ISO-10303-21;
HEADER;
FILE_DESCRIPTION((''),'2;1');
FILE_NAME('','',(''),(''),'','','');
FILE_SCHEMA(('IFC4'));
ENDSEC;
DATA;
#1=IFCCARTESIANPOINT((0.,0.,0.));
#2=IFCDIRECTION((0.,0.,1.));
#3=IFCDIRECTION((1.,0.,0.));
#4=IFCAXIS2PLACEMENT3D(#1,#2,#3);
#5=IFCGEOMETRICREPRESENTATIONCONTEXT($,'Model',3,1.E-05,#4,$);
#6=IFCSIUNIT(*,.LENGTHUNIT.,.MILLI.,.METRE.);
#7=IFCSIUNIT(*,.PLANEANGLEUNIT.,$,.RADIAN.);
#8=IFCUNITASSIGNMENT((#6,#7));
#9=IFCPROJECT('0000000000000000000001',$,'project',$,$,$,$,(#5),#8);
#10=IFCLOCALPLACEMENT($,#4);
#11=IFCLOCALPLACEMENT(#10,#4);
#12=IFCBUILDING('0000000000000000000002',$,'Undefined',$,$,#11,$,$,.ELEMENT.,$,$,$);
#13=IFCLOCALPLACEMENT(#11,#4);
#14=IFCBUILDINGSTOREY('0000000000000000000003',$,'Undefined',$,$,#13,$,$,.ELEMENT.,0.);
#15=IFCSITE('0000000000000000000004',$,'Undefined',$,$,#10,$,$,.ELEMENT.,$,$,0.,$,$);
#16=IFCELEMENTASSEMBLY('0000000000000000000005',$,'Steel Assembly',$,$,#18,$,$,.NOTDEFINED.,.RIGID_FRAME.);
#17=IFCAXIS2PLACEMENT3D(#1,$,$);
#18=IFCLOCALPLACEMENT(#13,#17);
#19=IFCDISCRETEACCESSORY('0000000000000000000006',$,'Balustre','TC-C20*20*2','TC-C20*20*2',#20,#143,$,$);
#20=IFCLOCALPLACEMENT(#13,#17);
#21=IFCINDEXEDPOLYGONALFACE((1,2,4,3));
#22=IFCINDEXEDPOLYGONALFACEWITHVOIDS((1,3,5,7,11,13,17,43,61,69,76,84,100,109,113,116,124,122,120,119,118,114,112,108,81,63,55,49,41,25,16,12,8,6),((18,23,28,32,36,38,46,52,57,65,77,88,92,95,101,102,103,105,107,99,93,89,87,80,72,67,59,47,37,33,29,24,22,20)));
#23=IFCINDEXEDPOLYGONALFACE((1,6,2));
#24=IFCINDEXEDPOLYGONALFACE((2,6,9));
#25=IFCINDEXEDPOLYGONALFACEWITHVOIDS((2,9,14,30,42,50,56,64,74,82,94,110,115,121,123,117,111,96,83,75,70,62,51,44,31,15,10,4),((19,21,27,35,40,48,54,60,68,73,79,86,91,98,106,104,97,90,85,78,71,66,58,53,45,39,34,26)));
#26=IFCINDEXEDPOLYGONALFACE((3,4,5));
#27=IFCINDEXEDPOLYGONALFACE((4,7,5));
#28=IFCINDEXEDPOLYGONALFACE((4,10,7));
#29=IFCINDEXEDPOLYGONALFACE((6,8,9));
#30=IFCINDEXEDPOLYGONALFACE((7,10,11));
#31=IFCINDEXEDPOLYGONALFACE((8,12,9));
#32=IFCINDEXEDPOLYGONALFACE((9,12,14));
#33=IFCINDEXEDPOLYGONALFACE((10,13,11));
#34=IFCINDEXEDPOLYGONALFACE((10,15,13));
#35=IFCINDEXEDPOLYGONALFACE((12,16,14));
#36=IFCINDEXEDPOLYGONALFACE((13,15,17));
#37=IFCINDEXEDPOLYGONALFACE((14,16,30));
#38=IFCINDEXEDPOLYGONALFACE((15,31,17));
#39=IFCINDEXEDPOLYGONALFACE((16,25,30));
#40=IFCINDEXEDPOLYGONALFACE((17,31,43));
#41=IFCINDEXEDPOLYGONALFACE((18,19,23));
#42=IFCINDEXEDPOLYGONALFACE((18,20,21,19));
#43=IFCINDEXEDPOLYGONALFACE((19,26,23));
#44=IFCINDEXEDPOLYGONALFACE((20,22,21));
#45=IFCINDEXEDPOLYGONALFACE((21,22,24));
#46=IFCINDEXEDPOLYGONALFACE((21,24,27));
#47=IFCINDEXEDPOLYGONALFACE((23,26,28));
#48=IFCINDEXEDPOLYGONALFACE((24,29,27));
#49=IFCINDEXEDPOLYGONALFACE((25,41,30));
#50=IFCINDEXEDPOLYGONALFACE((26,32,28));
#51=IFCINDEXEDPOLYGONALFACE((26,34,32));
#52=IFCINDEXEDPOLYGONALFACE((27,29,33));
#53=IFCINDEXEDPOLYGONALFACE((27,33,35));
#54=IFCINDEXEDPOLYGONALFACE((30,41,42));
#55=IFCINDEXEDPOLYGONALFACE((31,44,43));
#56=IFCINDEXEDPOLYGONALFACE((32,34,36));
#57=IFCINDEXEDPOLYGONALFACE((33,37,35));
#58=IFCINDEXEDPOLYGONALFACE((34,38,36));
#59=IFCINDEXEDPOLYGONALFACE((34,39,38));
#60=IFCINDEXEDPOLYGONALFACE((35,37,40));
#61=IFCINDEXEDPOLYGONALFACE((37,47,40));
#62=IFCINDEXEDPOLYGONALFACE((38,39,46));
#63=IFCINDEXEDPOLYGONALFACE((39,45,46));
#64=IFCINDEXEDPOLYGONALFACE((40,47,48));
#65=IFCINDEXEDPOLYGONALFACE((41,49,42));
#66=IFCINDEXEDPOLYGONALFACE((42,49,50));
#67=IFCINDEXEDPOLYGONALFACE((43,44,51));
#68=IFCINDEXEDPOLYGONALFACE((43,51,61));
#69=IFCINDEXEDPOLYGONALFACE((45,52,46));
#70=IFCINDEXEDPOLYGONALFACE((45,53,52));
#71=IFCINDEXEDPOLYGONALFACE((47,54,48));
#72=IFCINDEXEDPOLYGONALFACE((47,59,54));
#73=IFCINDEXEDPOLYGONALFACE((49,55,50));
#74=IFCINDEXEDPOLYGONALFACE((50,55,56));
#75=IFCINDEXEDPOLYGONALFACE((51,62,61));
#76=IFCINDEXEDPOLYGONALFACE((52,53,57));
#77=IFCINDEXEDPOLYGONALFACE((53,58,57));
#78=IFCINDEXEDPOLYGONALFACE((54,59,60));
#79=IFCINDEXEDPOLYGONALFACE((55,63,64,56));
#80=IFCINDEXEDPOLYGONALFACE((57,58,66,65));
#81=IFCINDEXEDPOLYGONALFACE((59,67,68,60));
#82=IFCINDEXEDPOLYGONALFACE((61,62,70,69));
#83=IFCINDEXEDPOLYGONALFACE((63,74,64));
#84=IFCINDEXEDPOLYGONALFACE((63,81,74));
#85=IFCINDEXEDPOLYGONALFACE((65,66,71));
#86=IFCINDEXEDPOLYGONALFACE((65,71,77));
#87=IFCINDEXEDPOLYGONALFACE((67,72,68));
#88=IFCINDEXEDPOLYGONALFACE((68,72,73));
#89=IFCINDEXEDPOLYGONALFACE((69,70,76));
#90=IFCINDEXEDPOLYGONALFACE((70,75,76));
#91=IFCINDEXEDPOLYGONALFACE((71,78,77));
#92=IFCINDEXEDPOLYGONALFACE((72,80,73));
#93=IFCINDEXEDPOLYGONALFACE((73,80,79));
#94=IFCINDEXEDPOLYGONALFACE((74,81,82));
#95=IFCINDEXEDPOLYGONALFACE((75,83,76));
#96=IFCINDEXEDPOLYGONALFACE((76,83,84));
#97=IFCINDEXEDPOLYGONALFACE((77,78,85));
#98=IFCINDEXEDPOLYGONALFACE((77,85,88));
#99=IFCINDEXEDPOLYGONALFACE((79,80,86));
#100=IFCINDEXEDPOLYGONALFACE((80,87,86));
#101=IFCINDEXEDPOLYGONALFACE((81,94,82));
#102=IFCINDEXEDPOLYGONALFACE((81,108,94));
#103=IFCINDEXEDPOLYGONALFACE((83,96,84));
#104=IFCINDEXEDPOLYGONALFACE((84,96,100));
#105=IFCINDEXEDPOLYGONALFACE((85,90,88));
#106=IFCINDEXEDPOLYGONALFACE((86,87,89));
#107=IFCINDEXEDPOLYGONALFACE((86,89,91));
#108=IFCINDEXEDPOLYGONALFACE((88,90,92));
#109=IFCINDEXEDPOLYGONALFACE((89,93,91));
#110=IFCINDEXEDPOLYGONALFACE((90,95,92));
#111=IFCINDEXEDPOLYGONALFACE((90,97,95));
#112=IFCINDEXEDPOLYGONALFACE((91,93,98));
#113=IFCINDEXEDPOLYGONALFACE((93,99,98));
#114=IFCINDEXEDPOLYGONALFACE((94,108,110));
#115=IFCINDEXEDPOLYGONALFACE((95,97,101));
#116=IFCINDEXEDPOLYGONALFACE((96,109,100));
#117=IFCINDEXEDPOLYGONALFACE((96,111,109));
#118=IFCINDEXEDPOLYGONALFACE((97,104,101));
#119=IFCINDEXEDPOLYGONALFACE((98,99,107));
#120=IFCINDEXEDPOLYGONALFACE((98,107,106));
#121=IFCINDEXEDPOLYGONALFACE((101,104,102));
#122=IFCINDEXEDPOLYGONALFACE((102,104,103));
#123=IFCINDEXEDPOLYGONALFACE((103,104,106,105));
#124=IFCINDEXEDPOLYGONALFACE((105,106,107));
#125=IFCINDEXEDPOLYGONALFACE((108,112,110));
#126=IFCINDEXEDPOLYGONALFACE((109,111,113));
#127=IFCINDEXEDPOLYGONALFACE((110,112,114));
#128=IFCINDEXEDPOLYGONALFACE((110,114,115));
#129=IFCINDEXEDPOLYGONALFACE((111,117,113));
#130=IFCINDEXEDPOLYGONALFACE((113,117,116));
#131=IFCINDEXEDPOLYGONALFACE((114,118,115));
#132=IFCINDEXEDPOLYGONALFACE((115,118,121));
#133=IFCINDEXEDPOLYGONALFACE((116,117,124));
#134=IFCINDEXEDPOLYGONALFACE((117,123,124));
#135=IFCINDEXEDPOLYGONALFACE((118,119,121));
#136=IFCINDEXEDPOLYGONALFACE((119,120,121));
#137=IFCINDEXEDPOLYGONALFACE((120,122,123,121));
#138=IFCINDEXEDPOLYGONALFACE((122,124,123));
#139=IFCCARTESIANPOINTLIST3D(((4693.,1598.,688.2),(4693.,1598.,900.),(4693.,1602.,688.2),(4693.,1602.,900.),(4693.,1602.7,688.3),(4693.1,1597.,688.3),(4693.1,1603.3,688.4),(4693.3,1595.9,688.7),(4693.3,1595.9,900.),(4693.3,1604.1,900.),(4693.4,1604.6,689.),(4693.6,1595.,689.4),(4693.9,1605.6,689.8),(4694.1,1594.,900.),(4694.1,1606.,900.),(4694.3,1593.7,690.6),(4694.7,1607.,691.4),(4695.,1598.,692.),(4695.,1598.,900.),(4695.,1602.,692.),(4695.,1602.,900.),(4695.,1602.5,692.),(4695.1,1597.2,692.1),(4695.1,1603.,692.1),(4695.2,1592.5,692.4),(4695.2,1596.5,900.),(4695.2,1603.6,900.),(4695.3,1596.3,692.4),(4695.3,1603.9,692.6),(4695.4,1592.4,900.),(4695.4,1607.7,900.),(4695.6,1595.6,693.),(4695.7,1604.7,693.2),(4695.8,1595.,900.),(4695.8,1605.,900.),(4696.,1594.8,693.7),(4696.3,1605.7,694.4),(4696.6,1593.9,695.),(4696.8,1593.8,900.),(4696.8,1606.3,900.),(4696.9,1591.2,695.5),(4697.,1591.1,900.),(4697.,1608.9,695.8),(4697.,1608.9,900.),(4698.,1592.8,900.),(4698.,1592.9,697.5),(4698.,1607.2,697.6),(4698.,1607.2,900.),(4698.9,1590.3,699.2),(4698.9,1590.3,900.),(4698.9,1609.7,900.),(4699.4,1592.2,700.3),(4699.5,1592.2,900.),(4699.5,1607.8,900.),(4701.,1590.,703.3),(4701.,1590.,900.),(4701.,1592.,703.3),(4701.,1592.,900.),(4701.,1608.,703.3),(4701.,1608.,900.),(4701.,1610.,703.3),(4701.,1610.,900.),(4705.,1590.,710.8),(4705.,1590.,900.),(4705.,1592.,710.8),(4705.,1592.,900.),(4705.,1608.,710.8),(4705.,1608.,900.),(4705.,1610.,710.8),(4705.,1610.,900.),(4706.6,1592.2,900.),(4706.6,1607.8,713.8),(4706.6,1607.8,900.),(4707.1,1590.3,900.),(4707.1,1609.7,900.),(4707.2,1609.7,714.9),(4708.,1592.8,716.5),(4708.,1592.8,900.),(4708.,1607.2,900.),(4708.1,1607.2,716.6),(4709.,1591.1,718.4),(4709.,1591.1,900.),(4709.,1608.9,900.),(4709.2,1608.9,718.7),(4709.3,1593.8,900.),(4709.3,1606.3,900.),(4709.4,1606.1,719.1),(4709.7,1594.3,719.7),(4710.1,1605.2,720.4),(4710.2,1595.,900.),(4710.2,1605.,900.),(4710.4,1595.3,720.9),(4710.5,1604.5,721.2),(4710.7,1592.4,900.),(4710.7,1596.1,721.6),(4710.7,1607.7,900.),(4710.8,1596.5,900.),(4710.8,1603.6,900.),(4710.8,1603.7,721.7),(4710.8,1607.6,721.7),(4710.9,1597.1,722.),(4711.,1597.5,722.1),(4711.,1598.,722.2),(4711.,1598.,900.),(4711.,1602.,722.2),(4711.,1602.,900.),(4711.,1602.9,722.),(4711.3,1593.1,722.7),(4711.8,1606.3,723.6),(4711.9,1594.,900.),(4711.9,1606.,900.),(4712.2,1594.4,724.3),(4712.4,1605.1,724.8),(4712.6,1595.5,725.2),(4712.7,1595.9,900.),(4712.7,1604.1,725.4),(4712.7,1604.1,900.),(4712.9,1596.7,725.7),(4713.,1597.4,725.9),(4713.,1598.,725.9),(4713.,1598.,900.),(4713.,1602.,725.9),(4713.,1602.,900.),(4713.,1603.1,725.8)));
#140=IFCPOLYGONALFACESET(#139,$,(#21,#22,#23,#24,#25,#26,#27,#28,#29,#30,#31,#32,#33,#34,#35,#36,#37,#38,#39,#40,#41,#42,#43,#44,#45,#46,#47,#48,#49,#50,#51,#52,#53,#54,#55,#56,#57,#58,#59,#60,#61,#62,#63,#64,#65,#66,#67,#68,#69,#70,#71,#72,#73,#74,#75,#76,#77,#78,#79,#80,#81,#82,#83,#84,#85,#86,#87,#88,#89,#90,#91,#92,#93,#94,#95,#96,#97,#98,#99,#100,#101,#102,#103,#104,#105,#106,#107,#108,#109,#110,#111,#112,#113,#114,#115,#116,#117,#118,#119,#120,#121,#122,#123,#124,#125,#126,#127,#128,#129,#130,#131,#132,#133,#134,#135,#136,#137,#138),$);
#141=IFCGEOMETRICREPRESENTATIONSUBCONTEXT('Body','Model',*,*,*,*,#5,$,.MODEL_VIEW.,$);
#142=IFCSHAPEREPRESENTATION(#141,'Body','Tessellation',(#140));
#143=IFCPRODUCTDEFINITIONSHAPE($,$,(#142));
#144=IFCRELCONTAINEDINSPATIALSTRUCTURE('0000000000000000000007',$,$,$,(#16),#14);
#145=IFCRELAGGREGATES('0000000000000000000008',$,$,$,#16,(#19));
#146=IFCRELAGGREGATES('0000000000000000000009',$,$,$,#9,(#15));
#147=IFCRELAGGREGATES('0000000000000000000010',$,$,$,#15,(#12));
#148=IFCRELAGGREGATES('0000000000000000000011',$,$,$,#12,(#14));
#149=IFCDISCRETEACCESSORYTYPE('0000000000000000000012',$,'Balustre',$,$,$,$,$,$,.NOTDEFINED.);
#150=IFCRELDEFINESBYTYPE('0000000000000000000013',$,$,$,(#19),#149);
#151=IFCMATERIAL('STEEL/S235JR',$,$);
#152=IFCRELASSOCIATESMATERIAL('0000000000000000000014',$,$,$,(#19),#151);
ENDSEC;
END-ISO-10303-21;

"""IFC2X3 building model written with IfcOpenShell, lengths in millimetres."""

from ifc_helpers import new_model, si_unit, frame, origin_with_axes, origin_2d_with_axis, place, context, subcontext, project, spatial, hollow_rectangle, extrude, clip, halfspace, material, type_object, element, aggregate, save


model = new_model("IFC2X3")

# Units and contexts
model_context = context("Model", 3, precision=1e-05, world=origin_with_axes())
body_context = subcontext(model_context, "Body", "Model", "MODEL_VIEW")
ifc_project = project(units=[si_unit("LENGTHUNIT", "METRE", prefix="MILLI"), si_unit("PLANEANGLEUNIT", "RADIAN")], contexts=[model_context])

# Site, building, storey
site_placement = place(None, origin_with_axes())
site = spatial("IfcSite", under=ifc_project, at=site_placement, Name="Undefined", CompositionType="ELEMENT", RefElevation=0.0)
building_placement = place(site_placement, origin_with_axes())
building = spatial("IfcBuilding", under=site, at=building_placement, Name="Undefined", CompositionType="ELEMENT")
storey_placement = place(building_placement, origin_with_axes())
storey = spatial("IfcBuildingStorey", under=building, at=storey_placement, Name="Undefined", CompositionType="ELEMENT", Elevation=0.0)

# Element assembly
assembly_1_placement = place(storey_placement, origin_with_axes())
assembly_1 = element("IfcElementAssembly", 1, at=assembly_1_placement, inside=storey, Name="Steel Assembly", AssemblyPlace="NOTDEFINED", PredefinedType="RIGID_FRAME")
ifc_material = material(Name="STEEL/S235JR")

# Shared definitions
discrete_accessory_type_1 = type_object("IfcDiscreteAccessoryType", Name="Balustre")

# Discrete accessory
discrete_accessory_1_placement = place(assembly_1_placement, frame((4703.0, 1600.0, 900.0), z_axis=(-0.000011, 1.0, 0.0), x_axis=(0.0, 0.0, -1.0)))
discrete_accessory_1 = element("IfcDiscreteAccessory", 2, at=discrete_accessory_1_placement, type_object=discrete_accessory_type_1, material=ifc_material, Name="Balustre", Description="TC-C20*20*2", ObjectType="TC-C20*20*2", context=body_context, shape_type="Clipping", body=[
    clip(extrude(hollow_rectangle(XDim=20.0, YDim=20.0, WallThickness=2.0, InnerFilletRadius=6.0, OuterFilletRadius=8.0, at=origin_2d_with_axis()), frame((212.0, 0.0, 0.0), z_axis=(-1.0, 0.0, 0.0), x_axis=(0.0, -1.0, 0.0)), (0.0, 0.0, 1.0), 212.0), halfspace(frame((221.5, 15.1, 0.0), z_axis=(-0.46842, 0.883506, 0.000005), x_axis=(0.0, -0.000005, 1.0)), True)),
])

aggregate(assembly_1, [discrete_accessory_1])

save(model, "model.ifc")
